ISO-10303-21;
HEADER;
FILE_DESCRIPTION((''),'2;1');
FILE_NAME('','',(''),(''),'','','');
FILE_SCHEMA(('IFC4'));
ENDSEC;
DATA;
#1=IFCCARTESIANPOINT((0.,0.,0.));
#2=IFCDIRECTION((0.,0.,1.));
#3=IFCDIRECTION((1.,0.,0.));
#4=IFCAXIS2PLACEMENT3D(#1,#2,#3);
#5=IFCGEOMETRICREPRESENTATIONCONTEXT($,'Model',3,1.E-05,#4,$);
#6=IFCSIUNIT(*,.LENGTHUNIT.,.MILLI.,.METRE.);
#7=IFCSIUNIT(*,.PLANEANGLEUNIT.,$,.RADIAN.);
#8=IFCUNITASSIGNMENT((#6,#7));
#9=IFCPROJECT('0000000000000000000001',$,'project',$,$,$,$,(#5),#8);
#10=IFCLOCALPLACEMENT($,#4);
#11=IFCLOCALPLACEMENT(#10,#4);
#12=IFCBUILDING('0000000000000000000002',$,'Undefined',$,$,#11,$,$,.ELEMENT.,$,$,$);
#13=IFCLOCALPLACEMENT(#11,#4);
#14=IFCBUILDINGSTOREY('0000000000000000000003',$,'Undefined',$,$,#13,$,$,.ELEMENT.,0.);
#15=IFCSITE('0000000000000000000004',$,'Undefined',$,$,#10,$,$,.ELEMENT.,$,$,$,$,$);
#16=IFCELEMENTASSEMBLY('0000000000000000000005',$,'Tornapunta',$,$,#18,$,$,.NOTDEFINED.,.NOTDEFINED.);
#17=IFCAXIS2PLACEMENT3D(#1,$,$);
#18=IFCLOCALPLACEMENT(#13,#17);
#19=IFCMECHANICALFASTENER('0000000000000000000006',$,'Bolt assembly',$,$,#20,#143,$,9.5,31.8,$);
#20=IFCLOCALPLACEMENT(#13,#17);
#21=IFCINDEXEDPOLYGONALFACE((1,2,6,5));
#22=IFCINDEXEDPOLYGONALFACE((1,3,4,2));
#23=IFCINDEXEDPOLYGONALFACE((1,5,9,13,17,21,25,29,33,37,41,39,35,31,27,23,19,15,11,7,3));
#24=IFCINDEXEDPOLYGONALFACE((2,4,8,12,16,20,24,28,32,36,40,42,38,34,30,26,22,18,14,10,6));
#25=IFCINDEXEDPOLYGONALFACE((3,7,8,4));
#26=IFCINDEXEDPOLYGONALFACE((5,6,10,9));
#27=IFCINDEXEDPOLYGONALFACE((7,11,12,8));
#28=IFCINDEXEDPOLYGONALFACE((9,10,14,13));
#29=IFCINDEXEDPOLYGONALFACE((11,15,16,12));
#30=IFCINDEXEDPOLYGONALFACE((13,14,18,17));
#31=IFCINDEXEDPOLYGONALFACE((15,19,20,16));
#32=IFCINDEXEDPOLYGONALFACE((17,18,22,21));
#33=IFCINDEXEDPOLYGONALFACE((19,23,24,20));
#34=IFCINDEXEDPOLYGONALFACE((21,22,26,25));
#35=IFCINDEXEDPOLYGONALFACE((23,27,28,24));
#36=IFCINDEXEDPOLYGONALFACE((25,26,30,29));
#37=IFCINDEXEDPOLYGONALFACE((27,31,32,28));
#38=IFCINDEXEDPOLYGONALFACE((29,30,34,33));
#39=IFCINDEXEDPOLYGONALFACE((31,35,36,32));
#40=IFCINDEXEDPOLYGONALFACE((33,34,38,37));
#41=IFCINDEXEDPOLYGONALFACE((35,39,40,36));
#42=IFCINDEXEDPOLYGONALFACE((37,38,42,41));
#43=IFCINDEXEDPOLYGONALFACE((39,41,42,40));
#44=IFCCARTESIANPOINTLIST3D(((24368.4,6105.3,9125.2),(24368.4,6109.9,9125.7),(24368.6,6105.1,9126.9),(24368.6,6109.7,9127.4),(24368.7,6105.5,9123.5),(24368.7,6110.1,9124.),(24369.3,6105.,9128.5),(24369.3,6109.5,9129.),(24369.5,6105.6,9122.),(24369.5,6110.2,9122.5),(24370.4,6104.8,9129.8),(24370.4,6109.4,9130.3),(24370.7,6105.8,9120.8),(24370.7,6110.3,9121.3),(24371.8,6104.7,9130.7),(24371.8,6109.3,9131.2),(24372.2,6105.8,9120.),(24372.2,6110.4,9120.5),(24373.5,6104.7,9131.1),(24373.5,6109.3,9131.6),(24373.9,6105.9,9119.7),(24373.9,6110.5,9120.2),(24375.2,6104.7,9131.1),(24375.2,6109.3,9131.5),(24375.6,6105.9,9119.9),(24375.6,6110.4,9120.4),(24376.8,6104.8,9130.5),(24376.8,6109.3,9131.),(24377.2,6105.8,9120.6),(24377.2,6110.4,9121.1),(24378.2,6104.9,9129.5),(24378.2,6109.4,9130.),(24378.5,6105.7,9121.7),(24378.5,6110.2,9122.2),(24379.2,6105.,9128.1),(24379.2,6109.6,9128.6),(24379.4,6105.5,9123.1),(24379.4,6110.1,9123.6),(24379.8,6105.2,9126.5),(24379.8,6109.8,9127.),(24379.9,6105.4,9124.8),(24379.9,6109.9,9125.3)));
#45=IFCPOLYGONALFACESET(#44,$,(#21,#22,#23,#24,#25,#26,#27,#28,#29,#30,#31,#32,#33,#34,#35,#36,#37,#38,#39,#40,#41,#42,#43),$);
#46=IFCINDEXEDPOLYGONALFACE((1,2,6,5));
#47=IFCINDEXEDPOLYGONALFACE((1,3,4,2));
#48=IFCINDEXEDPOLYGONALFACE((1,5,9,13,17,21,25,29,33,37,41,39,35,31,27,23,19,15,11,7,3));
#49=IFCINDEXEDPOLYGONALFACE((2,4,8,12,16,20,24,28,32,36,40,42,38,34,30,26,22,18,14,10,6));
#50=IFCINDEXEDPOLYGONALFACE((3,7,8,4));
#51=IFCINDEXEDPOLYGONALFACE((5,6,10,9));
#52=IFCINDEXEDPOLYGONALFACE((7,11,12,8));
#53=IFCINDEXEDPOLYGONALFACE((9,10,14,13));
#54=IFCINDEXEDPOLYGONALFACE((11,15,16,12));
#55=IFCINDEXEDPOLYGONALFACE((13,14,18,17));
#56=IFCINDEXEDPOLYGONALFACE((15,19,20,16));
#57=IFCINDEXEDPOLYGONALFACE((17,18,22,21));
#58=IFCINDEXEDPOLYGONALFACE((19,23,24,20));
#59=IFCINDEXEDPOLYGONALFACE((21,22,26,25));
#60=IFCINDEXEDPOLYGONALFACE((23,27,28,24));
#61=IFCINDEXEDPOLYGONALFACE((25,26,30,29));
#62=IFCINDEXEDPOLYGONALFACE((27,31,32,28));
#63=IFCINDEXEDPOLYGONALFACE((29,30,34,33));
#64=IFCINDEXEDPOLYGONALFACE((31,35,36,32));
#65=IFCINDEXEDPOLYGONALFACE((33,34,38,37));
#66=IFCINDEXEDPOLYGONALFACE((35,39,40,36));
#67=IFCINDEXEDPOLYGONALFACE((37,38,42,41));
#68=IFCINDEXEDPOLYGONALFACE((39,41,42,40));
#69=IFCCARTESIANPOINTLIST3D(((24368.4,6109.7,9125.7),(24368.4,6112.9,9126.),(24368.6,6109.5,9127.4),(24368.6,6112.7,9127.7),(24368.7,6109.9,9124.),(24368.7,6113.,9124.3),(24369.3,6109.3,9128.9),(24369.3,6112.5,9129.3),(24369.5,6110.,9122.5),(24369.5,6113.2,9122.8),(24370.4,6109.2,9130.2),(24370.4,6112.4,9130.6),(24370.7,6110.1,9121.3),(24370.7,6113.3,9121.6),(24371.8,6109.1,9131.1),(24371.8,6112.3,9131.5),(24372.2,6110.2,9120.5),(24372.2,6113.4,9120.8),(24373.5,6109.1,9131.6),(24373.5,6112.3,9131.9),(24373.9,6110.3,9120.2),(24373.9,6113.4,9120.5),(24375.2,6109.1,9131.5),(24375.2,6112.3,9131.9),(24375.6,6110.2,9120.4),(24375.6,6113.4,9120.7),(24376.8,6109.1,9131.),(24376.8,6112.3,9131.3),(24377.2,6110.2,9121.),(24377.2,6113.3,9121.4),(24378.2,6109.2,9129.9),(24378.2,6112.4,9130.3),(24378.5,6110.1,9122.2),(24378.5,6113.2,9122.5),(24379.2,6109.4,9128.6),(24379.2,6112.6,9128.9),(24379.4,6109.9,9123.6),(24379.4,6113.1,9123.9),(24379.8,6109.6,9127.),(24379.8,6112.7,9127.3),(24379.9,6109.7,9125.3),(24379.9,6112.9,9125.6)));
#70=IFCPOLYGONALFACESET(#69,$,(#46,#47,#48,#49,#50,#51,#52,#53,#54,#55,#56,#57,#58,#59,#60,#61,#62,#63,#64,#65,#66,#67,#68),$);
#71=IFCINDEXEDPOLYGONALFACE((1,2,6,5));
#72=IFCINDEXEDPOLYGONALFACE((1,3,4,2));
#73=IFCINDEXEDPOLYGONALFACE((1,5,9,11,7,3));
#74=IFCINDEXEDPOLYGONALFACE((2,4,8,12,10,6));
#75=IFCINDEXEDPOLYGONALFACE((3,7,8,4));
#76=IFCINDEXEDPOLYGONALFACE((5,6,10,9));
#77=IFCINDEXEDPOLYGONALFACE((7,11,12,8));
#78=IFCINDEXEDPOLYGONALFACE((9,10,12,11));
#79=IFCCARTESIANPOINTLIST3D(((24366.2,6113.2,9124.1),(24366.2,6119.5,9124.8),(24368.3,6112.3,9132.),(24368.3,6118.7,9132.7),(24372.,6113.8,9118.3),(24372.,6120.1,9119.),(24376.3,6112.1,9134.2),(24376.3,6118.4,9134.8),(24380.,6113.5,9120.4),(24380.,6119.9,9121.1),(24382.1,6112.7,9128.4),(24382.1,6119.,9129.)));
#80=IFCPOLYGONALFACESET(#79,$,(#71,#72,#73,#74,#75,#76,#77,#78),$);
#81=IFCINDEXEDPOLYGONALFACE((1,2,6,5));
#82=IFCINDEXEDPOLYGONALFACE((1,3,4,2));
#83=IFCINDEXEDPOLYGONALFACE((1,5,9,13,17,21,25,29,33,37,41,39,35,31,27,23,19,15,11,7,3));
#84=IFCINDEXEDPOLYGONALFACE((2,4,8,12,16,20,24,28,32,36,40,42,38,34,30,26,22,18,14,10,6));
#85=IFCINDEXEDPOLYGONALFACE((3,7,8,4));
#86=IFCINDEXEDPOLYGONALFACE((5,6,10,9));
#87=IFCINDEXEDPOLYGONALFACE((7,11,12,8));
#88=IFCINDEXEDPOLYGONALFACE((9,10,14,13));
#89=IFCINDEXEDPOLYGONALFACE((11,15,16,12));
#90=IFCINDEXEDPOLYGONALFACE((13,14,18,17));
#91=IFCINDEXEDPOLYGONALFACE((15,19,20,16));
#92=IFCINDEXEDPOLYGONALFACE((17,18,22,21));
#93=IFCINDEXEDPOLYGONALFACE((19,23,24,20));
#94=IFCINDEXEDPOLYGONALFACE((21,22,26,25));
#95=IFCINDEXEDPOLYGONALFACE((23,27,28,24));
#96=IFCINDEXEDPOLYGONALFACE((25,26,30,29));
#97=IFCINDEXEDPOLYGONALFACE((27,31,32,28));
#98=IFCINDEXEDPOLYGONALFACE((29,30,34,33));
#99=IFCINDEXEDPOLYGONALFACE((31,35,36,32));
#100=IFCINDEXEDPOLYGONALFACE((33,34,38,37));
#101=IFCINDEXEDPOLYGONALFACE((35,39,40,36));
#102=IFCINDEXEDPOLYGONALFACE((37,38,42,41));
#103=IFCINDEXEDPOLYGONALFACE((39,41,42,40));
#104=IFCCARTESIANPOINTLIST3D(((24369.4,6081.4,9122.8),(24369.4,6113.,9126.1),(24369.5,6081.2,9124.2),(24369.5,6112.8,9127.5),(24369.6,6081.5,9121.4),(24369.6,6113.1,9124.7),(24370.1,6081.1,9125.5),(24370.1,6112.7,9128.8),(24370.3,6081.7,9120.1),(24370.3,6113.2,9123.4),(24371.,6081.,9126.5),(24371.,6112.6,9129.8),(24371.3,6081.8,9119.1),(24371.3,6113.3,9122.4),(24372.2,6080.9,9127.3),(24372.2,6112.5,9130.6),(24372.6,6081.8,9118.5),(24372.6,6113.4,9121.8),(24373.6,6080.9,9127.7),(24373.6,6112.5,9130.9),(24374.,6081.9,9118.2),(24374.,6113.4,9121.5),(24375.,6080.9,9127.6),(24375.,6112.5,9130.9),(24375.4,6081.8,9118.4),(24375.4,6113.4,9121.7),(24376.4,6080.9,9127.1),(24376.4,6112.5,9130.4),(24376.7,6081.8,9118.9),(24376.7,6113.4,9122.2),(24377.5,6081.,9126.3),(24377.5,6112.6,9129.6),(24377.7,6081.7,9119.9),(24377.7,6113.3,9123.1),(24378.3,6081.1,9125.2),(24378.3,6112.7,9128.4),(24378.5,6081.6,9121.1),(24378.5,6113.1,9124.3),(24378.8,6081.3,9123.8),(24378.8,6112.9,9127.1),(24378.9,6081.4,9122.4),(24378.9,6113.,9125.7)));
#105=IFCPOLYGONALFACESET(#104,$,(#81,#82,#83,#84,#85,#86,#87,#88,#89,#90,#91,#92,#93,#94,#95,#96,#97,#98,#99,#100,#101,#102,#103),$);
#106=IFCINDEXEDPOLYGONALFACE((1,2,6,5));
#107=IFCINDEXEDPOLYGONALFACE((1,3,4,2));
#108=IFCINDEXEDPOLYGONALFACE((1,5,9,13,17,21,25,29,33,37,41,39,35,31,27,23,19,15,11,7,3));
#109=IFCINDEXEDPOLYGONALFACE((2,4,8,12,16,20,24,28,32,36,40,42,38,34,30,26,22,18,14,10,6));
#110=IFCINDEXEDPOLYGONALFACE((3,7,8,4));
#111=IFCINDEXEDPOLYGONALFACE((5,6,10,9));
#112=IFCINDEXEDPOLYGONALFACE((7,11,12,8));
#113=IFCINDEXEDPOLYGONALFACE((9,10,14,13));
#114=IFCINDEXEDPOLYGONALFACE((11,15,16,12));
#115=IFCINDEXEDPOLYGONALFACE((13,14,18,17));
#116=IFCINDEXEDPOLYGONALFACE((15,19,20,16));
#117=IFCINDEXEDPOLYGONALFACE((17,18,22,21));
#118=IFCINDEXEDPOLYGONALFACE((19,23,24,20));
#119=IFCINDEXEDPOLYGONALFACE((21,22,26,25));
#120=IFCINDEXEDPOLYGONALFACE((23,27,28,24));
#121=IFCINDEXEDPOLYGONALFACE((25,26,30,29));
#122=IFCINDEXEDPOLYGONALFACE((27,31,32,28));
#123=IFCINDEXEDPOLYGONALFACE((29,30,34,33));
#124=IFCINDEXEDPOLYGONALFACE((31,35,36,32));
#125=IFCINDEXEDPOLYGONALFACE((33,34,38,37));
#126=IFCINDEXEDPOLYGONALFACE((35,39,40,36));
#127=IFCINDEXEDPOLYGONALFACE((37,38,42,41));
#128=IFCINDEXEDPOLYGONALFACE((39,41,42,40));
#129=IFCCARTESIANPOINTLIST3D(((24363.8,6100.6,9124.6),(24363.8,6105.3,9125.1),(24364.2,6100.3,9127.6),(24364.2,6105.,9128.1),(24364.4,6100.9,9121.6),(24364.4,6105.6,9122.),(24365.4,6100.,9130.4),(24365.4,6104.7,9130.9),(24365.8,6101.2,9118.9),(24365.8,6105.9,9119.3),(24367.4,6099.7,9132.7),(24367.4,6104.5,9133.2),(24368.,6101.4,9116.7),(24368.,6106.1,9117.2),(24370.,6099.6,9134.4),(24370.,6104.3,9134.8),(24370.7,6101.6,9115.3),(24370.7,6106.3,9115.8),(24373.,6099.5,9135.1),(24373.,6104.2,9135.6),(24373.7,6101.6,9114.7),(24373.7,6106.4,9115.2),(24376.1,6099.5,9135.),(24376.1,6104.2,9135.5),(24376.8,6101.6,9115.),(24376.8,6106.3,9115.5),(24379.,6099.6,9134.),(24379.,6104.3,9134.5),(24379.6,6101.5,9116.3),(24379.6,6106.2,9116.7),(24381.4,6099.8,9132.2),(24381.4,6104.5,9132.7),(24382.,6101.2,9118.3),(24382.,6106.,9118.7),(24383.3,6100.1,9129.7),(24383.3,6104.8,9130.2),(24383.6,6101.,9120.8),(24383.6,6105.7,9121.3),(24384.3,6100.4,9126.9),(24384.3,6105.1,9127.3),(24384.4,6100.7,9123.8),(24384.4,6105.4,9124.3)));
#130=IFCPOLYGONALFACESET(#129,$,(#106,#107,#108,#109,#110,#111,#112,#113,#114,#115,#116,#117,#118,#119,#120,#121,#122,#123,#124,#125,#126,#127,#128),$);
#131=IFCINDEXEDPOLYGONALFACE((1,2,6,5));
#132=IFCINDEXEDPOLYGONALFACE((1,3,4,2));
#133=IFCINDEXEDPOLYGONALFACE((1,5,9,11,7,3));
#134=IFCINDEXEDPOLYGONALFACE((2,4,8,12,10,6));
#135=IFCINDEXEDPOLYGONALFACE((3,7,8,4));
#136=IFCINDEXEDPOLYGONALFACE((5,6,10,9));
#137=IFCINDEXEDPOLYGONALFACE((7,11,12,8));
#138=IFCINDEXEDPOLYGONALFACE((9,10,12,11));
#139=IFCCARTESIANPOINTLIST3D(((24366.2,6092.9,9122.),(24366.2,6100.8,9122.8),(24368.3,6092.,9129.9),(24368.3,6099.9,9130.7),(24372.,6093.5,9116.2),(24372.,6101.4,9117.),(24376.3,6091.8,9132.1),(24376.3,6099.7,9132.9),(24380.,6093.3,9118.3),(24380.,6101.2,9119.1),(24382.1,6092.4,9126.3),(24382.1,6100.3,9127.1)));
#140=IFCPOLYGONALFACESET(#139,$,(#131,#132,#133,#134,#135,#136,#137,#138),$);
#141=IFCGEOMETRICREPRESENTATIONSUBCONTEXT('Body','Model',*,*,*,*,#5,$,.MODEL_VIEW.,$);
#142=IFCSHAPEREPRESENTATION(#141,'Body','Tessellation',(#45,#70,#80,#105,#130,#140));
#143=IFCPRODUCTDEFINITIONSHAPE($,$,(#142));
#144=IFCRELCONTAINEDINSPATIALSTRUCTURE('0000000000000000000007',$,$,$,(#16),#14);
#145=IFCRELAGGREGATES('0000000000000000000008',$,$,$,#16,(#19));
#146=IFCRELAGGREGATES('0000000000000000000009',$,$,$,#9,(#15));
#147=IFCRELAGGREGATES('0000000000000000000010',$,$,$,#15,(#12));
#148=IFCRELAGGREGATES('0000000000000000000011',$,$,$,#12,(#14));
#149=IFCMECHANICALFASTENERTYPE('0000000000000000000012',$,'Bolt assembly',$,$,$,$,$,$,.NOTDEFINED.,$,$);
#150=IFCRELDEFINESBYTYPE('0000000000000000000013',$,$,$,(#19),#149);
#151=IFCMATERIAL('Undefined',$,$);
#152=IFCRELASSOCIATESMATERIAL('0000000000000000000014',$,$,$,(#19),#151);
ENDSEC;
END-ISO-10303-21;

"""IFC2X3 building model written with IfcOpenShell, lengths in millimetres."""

from ifc_helpers import new_model, si_unit, frame, origin_with_axes, origin_2d_with_axis, place, context, subcontext, project, spatial, polyline, circle, outline, extrude, source, transform, mapped, material, type_object, element, aggregate, save


model = new_model("IFC2X3")

# Units and contexts
model_context = context("Model", 3, precision=1e-05, world=origin_with_axes())
body_context = subcontext(model_context, "Body", "Model", "MODEL_VIEW")
ifc_project = project(units=[si_unit("LENGTHUNIT", "METRE", prefix="MILLI"), si_unit("PLANEANGLEUNIT", "RADIAN")], contexts=[model_context])

# Site, building, storey
site_placement = place(None, origin_with_axes())
site = spatial("IfcSite", under=ifc_project, at=site_placement, Name="Undefined", CompositionType="ELEMENT")
building_placement = place(site_placement, origin_with_axes())
building = spatial("IfcBuilding", under=site, at=building_placement, Name="Undefined", CompositionType="ELEMENT")
storey_placement = place(building_placement, origin_with_axes())
storey = spatial("IfcBuildingStorey", under=building, at=storey_placement, Name="Undefined", CompositionType="ELEMENT", Elevation=0.0)

# Shared definitions
ifc_material_1 = material(Name="Undefined")
mechanical_fastener_type = type_object("IfcMechanicalFastenerType", Name="Bolt assembly")

# Element assembly
assembly_1_placement = place(storey_placement, origin_with_axes())
assembly_1 = element("IfcElementAssembly", 1, at=assembly_1_placement, inside=storey, Name="Tornapunta", AssemblyPlace="NOTDEFINED", PredefinedType="NOTDEFINED")

# Mechanical fastener
shared_shape_1 = source(origin_with_axes(), body_context, "Body", "SweptSolid", [
    extrude(circle(Radius=5.8, at=origin_2d_with_axis()), frame((0.0, -0.1, 0.0), z_axis=(0.0, 1.0, 0.0), x_axis=(1.0, 0.0, 0.0)), (0.0, 0.0, 1.0), 4.6),
    extrude(circle(Radius=5.8, at=origin_2d_with_axis()), frame((0.0, -3.1, 0.0), z_axis=(0.0, 1.0, 0.0), x_axis=(1.0, 0.0, 0.0)), (0.0, 0.0, 1.0), 3.2),
    extrude(outline(polyline([(7.1, -4.1), (7.1, 4.1), (0.0, 8.2), (-7.1, 4.1), (-7.1, -4.1), (0.0, -8.2), (7.1, -4.1)])), frame((0.0, -9.5, 0.0), z_axis=(0.0, 1.0, 0.0), x_axis=(1.0, 0.0, 0.0)), (0.0, 0.0, 1.0), 6.3),
    extrude(circle(Radius=4.8, at=origin_2d_with_axis()), frame((0.0, -3.2, 0.0), z_axis=(0.0, 1.0, 0.0), x_axis=(1.0, 0.0, 0.0)), (0.0, 0.0, 1.0), 31.8),
    extrude(circle(Radius=10.3, at=origin_2d_with_axis()), frame((0.0, 4.5, 0.0), z_axis=(0.0, 1.0, 0.0), x_axis=(1.0, 0.0, 0.0)), (0.0, 0.0, 1.0), 4.8),
    extrude(outline(polyline([(7.1, -4.1), (7.1, 4.1), (0.0, 8.2), (-7.1, 4.1), (-7.1, -4.1), (0.0, -8.2), (7.1, -4.1)])), frame((0.0, 9.3, 0.0), z_axis=(0.0, 1.0, 0.0), x_axis=(1.0, 0.0, 0.0)), (0.0, 0.0, 1.0), 7.9),
])
mechanical_fastener_1_placement = place(assembly_1_placement, frame((24374.1, 6109.8, 9125.9), z_axis=(0.707107, 0.072947, -0.703334), x_axis=(0.707107, -0.072947, 0.703334)))
mechanical_fastener_1 = element("IfcMechanicalFastener", 2, at=mechanical_fastener_1_placement, type_object=mechanical_fastener_type, material=ifc_material_1, Name="Bolt assembly", NominalDiameter=9.5, NominalLength=31.8, context=body_context, shape_type="MappedRepresentation", body=[
    mapped(shared_shape_1, transform((0.0, 0.0, 0.0))),
])
aggregate(assembly_1, [mechanical_fastener_1])

save(model, "model.ifc")
